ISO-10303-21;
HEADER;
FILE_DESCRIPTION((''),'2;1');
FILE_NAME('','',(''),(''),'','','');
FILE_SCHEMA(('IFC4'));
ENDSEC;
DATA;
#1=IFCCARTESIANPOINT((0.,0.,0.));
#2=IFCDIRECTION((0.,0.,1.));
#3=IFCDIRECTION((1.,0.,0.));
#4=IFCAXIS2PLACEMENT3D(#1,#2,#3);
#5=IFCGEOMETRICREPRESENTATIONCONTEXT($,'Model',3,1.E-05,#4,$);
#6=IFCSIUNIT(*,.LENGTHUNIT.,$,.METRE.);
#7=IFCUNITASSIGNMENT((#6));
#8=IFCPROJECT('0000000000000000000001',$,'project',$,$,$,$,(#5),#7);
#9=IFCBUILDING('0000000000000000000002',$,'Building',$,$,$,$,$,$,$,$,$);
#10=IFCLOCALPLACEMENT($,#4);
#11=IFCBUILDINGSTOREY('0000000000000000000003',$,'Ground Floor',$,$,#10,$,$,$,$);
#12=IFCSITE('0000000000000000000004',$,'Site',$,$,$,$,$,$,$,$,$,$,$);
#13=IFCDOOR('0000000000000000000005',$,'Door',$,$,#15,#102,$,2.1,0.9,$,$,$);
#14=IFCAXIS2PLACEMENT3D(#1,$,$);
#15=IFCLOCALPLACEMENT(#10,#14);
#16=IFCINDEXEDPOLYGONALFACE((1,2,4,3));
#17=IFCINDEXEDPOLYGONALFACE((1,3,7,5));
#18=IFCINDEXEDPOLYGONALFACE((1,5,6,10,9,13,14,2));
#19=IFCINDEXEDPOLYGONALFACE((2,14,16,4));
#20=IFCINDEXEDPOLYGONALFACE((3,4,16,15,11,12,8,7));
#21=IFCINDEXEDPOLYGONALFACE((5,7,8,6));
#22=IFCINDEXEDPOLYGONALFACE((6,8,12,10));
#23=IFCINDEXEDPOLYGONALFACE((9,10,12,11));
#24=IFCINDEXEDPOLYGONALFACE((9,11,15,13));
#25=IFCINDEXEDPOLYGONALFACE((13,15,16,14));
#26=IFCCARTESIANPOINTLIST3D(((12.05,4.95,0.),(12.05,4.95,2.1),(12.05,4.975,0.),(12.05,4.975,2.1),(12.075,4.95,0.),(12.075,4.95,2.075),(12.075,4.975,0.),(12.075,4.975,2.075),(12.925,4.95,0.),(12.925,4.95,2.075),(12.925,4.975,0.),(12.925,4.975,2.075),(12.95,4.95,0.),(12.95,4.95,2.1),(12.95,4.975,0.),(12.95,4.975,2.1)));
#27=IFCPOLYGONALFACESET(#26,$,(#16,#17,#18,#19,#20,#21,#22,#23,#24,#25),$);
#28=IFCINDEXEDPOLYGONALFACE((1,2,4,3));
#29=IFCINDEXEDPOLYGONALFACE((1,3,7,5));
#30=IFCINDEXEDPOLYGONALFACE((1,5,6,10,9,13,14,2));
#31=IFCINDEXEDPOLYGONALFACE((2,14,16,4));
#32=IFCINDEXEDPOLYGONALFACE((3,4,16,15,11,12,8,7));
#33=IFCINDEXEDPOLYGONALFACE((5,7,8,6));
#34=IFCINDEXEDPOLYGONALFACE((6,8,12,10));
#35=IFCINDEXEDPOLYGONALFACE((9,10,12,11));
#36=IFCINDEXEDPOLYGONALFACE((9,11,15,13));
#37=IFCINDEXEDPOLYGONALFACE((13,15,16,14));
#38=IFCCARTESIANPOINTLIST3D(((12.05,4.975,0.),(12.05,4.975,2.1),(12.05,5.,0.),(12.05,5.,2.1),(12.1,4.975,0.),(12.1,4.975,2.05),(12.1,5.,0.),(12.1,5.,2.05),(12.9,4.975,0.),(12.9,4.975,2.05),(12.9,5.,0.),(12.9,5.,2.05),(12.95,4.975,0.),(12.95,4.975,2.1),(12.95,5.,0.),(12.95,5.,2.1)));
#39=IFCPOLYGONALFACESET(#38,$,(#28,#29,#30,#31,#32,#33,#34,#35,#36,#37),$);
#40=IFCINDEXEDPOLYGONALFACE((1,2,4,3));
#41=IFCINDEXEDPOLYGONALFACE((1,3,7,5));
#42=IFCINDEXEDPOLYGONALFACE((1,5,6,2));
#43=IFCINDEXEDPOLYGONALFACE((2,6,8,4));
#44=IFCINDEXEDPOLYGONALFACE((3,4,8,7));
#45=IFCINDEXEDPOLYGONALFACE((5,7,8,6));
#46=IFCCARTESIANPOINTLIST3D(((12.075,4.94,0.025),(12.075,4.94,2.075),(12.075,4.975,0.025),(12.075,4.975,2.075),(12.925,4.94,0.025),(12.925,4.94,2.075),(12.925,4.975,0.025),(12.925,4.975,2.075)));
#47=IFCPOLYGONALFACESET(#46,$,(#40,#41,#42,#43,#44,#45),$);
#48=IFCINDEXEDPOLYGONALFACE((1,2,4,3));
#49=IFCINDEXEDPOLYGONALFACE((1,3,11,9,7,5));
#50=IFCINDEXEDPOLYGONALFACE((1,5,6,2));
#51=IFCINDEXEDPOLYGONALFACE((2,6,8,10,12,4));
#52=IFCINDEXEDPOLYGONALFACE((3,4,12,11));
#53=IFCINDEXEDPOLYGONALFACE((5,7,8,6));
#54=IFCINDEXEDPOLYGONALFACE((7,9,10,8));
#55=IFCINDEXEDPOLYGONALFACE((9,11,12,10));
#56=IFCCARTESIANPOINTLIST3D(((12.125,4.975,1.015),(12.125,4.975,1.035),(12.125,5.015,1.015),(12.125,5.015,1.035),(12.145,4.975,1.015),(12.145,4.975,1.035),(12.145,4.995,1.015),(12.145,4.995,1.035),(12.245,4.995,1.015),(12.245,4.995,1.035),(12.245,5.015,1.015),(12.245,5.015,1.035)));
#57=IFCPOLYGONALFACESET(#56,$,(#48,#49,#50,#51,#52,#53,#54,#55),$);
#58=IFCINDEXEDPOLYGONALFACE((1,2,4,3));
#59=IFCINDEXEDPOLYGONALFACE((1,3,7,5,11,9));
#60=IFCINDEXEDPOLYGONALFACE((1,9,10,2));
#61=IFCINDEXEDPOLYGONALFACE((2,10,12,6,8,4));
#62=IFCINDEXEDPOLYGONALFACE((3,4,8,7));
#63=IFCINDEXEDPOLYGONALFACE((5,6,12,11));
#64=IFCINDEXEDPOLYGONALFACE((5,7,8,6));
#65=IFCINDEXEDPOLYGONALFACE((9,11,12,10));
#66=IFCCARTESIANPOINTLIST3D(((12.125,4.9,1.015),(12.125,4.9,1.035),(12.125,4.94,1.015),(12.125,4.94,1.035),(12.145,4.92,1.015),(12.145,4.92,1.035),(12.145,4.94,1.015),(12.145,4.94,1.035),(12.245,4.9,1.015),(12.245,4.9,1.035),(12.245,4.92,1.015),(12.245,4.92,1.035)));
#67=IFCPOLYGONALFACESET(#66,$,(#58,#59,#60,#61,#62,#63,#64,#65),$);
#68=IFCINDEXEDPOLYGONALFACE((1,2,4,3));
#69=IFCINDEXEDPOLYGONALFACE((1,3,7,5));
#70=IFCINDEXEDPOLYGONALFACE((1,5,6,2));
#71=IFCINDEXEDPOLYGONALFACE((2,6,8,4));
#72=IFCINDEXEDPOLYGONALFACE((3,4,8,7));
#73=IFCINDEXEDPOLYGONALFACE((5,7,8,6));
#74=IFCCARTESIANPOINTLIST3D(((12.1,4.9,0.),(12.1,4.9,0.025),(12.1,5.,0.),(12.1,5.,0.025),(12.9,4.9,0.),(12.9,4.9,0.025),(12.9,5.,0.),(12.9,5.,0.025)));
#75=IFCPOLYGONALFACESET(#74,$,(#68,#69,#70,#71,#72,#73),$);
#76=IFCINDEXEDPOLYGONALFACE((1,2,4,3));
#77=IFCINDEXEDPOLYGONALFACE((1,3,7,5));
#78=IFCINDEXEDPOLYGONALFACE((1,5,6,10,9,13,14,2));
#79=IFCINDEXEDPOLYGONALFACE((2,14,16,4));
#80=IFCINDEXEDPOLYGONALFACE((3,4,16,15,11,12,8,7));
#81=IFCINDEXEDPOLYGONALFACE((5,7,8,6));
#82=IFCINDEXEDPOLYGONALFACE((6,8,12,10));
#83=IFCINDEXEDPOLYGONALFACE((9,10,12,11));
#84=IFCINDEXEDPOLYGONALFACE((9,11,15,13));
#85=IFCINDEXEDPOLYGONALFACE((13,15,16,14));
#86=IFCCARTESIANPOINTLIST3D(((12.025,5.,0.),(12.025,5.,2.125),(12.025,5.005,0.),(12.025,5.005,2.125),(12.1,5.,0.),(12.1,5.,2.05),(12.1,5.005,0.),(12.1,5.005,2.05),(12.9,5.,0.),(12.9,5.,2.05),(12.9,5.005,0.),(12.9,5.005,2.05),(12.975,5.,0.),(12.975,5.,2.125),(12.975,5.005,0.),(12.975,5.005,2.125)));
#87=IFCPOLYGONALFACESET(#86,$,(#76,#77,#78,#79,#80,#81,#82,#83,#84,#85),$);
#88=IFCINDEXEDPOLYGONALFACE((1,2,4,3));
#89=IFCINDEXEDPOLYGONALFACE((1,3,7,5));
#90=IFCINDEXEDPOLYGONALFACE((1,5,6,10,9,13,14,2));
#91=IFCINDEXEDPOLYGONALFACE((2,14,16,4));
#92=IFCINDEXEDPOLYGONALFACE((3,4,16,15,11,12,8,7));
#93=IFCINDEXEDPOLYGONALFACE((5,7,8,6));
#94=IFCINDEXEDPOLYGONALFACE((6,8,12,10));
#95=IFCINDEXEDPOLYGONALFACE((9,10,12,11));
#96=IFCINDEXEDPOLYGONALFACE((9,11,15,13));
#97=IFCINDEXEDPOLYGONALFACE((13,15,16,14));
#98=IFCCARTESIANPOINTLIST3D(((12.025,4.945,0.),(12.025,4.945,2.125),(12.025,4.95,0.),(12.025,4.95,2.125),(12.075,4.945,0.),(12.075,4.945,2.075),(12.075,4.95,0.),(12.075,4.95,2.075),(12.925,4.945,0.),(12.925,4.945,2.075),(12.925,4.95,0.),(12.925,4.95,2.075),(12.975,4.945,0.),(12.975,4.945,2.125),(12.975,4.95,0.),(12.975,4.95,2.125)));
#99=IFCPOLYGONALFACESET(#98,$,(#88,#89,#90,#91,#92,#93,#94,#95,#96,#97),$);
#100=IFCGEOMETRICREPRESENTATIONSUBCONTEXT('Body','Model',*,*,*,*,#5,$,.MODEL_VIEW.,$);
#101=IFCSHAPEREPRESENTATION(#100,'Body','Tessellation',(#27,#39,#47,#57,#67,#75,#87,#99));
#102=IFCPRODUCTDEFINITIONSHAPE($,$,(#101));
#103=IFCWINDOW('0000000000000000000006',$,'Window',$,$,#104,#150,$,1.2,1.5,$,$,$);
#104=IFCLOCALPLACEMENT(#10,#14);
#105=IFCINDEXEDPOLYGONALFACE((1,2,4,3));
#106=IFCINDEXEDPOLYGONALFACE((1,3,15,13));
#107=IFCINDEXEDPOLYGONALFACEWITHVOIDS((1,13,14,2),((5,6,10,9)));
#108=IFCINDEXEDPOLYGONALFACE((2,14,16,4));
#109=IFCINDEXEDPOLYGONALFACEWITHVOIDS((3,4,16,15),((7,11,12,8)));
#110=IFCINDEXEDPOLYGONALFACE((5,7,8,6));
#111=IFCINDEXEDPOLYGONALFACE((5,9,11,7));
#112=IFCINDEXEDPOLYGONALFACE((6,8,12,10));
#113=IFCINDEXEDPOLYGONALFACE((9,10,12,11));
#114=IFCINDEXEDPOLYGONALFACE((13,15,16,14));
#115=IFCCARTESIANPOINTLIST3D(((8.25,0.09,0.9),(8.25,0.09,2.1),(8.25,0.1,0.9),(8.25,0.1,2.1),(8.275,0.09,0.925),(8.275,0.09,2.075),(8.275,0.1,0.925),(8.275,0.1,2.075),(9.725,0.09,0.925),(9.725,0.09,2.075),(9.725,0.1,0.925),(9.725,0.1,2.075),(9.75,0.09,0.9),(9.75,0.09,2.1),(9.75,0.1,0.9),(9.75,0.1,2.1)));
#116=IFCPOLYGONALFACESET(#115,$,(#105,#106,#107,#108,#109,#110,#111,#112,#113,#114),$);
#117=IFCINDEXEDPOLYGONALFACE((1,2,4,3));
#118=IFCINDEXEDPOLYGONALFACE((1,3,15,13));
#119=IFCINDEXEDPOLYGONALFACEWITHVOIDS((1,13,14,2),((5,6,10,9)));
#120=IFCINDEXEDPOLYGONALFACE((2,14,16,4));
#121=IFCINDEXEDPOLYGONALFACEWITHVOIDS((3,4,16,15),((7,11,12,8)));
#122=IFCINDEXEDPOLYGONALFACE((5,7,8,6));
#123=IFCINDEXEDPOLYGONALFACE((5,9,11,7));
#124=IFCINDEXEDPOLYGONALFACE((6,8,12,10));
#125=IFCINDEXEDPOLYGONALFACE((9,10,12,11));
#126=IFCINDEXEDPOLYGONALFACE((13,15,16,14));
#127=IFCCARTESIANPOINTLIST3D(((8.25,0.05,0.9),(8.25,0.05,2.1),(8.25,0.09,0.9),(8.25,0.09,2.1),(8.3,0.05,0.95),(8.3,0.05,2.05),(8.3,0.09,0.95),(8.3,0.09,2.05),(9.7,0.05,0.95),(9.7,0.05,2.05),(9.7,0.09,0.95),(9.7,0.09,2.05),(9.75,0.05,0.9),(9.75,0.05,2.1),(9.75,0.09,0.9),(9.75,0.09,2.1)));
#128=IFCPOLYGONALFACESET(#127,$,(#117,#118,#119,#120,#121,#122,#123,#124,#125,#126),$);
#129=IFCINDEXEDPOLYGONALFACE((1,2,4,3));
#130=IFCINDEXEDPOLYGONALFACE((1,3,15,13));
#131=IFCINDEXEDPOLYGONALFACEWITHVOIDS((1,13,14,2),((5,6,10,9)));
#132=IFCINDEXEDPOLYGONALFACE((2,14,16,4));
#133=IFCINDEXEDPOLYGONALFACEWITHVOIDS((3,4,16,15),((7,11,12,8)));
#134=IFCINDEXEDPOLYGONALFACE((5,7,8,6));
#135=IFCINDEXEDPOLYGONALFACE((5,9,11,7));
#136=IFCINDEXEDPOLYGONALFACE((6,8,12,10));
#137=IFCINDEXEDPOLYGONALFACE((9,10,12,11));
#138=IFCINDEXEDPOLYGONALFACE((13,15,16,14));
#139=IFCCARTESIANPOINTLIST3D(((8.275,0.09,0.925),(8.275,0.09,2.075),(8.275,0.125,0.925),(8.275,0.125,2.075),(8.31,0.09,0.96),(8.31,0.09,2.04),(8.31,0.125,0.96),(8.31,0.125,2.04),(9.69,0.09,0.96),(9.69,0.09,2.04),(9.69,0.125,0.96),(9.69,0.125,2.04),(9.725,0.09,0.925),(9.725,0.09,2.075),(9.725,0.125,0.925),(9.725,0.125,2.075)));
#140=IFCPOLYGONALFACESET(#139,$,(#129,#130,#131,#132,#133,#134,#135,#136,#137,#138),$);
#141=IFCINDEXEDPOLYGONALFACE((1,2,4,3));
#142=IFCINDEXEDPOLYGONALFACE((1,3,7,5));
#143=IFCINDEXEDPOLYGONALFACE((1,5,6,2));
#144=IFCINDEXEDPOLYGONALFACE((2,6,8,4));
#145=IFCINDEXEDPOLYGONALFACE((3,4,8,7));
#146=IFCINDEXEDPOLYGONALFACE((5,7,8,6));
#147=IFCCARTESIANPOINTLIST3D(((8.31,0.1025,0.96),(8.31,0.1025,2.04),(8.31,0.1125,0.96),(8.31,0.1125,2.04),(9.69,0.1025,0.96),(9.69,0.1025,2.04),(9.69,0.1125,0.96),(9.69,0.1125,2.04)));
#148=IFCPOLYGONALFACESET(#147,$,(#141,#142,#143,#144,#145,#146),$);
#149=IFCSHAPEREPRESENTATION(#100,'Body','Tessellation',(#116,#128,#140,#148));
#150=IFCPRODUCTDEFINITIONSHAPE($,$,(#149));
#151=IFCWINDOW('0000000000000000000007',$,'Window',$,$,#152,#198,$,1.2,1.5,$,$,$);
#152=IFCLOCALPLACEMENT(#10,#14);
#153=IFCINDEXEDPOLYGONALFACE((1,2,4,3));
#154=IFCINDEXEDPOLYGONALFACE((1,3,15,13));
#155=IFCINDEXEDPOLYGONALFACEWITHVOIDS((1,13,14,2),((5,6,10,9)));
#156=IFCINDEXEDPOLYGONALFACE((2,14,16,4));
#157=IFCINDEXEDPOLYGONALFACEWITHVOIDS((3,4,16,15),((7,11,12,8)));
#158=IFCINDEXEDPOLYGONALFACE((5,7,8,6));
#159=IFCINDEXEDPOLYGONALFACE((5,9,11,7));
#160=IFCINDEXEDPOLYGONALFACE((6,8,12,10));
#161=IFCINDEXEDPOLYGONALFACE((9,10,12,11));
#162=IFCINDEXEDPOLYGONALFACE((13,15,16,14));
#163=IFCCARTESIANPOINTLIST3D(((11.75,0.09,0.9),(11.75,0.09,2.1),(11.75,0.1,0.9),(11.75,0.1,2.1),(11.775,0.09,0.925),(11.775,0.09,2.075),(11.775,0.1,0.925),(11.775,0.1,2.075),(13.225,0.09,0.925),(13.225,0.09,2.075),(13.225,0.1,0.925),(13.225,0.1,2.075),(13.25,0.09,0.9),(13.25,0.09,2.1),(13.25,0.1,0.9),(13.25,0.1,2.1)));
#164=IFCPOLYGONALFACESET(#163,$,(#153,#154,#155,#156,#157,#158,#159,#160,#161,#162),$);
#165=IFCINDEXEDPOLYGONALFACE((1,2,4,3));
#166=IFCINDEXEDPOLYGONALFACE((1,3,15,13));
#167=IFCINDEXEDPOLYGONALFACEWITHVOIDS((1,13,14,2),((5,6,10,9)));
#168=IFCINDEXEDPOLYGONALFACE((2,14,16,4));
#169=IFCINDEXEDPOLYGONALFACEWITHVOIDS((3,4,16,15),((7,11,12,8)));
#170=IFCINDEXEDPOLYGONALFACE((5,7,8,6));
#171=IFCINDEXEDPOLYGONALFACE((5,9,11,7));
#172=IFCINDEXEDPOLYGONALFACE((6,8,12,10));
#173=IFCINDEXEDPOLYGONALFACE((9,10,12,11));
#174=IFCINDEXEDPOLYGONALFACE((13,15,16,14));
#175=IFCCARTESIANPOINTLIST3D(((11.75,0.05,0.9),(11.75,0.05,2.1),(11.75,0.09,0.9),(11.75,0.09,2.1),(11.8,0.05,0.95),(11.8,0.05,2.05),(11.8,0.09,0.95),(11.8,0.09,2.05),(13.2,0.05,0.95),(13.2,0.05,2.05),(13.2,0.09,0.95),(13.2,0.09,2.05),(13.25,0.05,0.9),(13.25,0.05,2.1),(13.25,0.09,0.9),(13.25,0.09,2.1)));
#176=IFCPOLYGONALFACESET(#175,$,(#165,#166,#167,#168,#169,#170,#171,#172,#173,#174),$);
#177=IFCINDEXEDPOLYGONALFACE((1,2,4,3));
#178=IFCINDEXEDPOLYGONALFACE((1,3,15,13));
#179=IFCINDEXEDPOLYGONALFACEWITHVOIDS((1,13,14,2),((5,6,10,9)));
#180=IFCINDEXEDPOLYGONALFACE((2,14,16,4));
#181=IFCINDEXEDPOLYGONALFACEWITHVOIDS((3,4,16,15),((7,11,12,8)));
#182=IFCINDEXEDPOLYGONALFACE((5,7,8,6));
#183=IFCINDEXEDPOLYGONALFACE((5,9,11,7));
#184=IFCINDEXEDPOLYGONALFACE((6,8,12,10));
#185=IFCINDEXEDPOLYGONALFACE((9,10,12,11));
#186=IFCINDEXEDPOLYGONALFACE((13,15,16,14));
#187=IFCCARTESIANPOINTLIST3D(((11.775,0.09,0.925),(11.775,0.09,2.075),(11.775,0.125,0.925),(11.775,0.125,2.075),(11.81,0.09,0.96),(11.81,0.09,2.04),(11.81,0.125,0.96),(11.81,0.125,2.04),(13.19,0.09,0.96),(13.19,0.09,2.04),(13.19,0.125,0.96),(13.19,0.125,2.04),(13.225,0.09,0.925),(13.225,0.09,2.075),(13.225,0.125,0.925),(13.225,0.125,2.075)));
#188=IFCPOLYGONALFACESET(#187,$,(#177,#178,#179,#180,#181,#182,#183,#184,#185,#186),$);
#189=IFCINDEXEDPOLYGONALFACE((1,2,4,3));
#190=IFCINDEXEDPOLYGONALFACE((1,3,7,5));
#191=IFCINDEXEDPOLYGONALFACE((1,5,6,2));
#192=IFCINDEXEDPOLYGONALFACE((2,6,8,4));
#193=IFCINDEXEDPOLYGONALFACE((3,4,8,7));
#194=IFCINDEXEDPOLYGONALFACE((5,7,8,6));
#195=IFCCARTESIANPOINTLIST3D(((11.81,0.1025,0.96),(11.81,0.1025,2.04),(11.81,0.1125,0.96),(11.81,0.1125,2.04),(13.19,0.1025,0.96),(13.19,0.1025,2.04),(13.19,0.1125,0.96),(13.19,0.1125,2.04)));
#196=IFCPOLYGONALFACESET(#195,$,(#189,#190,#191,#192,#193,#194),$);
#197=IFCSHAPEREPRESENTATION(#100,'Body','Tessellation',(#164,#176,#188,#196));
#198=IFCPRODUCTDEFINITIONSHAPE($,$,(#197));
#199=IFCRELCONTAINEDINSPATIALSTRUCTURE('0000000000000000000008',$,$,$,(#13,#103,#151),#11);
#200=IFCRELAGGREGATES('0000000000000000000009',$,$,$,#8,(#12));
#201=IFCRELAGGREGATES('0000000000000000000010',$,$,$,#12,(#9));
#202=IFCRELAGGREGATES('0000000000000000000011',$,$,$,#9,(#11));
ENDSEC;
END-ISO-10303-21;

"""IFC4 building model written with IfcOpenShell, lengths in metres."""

from ifc_helpers import new_model, si_unit, frame, origin_with_axes, place, context, subcontext, project, spatial, line, indexed_curve, outline, extrude, element, save


model = new_model("IFC4")

# Units and contexts
model_context = context("Model", 3, precision=1e-05, world=origin_with_axes())
body_context = subcontext(model_context, "Body", "Model", "MODEL_VIEW")
ifc_project = project(units=[si_unit("LENGTHUNIT", "METRE")], contexts=[model_context])

# Site, building, storey
site = spatial("IfcSite", under=ifc_project, Name="Site")
building = spatial("IfcBuilding", under=site, Name="Building")
storey_placement = place(None, origin_with_axes())
storey = spatial("IfcBuildingStorey", under=building, at=storey_placement, Name="Ground Floor")

# Door
door_1_placement = place(storey_placement, frame((12.95, 5.0, 0.0), z_axis=(0.0, 0.0, 1.0), x_axis=(-1.0, 0.0, 0.0)))
element("IfcDoor", 1, at=door_1_placement, inside=storey, Name="Door", OverallHeight=2.1, OverallWidth=0.9, context=body_context, shape_type="SweptSolid", body=[
    extrude(outline(indexed_curve([(0.0, 0.0), (0.0, 2.1), (0.9, 2.1), (0.9, 0.0), (0.875, 0.0), (0.875, 2.075), (0.025, 2.075), (0.025, 0.0)], segments=[line(1, 2, 3, 4, 5, 6, 7, 8, 1)])), frame((0.0, 0.025, 0.0), z_axis=(0.0, -1.0, 0.0), x_axis=(1.0, 0.0, 0.0)), (0.0, 0.0, -1.0), 0.025),
    extrude(outline(indexed_curve([(0.0, 0.0), (0.0, 2.1), (0.9, 2.1), (0.9, 0.0), (0.85, 0.0), (0.85, 2.05), (0.05, 2.05), (0.05, 0.0)], segments=[line(1, 2, 3, 4, 5, 6, 7, 8, 1)])), frame((0.0, 0.0, 0.0), z_axis=(0.0, -1.0, 0.0), x_axis=(1.0, 0.0, 0.0)), (0.0, 0.0, -1.0), 0.025),
    extrude(outline(indexed_curve([(0.0, 0.0), (0.85, 0.0), (0.85, 0.035), (0.0, 0.035)], segments=[line(1, 2, 3, 4, 1)])), frame((0.025, 0.025, 0.025), z_axis=(0.0, 0.0, 1.0), x_axis=(1.0, 0.0, 0.0)), (0.0, 0.0, 1.0), 2.05),
    extrude(outline(indexed_curve([(0.0, 0.0), (0.0, -0.04), (-0.12, -0.04), (-0.12, -0.02), (-0.02, -0.02), (-0.02, 0.0)], segments=[line(1, 2, 3, 4, 5, 6, 1)])), frame((0.825, 0.025, 1.015), z_axis=(0.0, 0.0, 1.0), x_axis=(1.0, 0.0, 0.0)), (0.0, 0.0, 1.0), 0.02),
    extrude(outline(indexed_curve([(0.0, 0.0), (0.0, 0.04), (-0.12, 0.04), (-0.12, 0.02), (-0.02, 0.02), (-0.02, 0.0)], segments=[line(1, 2, 3, 4, 5, 6, 1)])), frame((0.825, 0.06, 1.015), z_axis=(0.0, 0.0, 1.0), x_axis=(1.0, 0.0, 0.0)), (0.0, 0.0, 1.0), 0.02),
    extrude(outline(indexed_curve([(0.0, 0.0), (0.8, 0.0), (0.8, 0.1), (0.0, 0.1)], segments=[line(1, 2, 3, 4, 1)])), frame((0.05, 0.0, 0.0), z_axis=(0.0, 0.0, 1.0), x_axis=(1.0, 0.0, 0.0)), (0.0, 0.0, 1.0), 0.025),
    extrude(outline(indexed_curve([(0.0, 0.0), (0.0, 2.125), (0.95, 2.125), (0.95, 0.0), (0.875, 0.0), (0.875, 2.05), (0.075, 2.05), (0.075, 0.0)], segments=[line(1, 2, 3, 4, 5, 6, 7, 8, 1)])), frame((-0.025, -0.005, 0.0), z_axis=(0.0, -1.0, 0.0), x_axis=(1.0, 0.0, 0.0)), (0.0, 0.0, -1.0), 0.005),
    extrude(outline(indexed_curve([(0.0, 0.0), (0.0, 2.125), (0.95, 2.125), (0.95, 0.0), (0.9, 0.0), (0.9, 2.075), (0.05, 2.075), (0.05, 0.0)], segments=[line(1, 2, 3, 4, 5, 6, 7, 8, 1)])), frame((-0.025, 0.05, 0.0), z_axis=(0.0, -1.0, 0.0), x_axis=(1.0, 0.0, 0.0)), (0.0, 0.0, -1.0), 0.005),
])

# Windows
for number, where, z_axis, x_axis, name in (
    (2, (8.25, 0.0, 0.9), (0.0, 0.0, 1.0), (1.0, 0.0, 0.0), "Window"),
    (3, (11.75, 0.0, 0.9), (0.0, 0.0, 1.0), (1.0, 0.0, 0.0), "Window"),
):
    element("IfcWindow", number, at=place(storey_placement, frame(where, z_axis=z_axis, x_axis=x_axis)), inside=storey, Name=name, OverallHeight=1.2, OverallWidth=1.5, context=body_context, shape_type="SweptSolid", body=[
        extrude(outline(indexed_curve([(0.0, 0.0), (1.5, 0.0), (1.5, 1.2), (0.0, 1.2)], segments=[line(1, 2, 3, 4, 1)]), holes=[indexed_curve([(0.025, 0.025), (1.475, 0.025), (1.475, 1.175), (0.025, 1.175)], segments=[line(1, 2, 3, 4, 1)])]), frame((0.0, 0.09, 0.0), z_axis=(0.0, -1.0, 0.0), x_axis=(1.0, 0.0, 0.0)), (0.0, 0.0, -1.0), 0.01),
        extrude(outline(indexed_curve([(0.0, 0.0), (1.5, 0.0), (1.5, 1.2), (0.0, 1.2)], segments=[line(1, 2, 3, 4, 1)]), holes=[indexed_curve([(0.05, 0.05), (1.45, 0.05), (1.45, 1.15), (0.05, 1.15)], segments=[line(1, 2, 3, 4, 1)])]), frame((0.0, 0.05, 0.0), z_axis=(0.0, -1.0, 0.0), x_axis=(1.0, 0.0, 0.0)), (0.0, 0.0, -1.0), 0.04),
        extrude(outline(indexed_curve([(0.0, 0.0), (1.45, 0.0), (1.45, 1.15), (0.0, 1.15)], segments=[line(1, 2, 3, 4, 1)]), holes=[indexed_curve([(0.035, 0.035), (1.415, 0.035), (1.415, 1.115), (0.035, 1.115)], segments=[line(1, 2, 3, 4, 1)])]), frame((0.025, 0.09, 0.025), z_axis=(0.0, -1.0, 0.0), x_axis=(1.0, 0.0, 0.0)), (0.0, 0.0, -1.0), 0.035),
        extrude(outline(indexed_curve([(0.035, 0.035), (1.415, 0.035), (1.415, 1.115), (0.035, 1.115)], segments=[line(1, 2, 3, 4, 1)])), frame((0.025, 0.1025, 0.025), z_axis=(0.0, -1.0, 0.0), x_axis=(1.0, 0.0, 0.0)), (0.0, 0.0, -1.0), 0.01),
    ])

save(model, "model.ifc")
